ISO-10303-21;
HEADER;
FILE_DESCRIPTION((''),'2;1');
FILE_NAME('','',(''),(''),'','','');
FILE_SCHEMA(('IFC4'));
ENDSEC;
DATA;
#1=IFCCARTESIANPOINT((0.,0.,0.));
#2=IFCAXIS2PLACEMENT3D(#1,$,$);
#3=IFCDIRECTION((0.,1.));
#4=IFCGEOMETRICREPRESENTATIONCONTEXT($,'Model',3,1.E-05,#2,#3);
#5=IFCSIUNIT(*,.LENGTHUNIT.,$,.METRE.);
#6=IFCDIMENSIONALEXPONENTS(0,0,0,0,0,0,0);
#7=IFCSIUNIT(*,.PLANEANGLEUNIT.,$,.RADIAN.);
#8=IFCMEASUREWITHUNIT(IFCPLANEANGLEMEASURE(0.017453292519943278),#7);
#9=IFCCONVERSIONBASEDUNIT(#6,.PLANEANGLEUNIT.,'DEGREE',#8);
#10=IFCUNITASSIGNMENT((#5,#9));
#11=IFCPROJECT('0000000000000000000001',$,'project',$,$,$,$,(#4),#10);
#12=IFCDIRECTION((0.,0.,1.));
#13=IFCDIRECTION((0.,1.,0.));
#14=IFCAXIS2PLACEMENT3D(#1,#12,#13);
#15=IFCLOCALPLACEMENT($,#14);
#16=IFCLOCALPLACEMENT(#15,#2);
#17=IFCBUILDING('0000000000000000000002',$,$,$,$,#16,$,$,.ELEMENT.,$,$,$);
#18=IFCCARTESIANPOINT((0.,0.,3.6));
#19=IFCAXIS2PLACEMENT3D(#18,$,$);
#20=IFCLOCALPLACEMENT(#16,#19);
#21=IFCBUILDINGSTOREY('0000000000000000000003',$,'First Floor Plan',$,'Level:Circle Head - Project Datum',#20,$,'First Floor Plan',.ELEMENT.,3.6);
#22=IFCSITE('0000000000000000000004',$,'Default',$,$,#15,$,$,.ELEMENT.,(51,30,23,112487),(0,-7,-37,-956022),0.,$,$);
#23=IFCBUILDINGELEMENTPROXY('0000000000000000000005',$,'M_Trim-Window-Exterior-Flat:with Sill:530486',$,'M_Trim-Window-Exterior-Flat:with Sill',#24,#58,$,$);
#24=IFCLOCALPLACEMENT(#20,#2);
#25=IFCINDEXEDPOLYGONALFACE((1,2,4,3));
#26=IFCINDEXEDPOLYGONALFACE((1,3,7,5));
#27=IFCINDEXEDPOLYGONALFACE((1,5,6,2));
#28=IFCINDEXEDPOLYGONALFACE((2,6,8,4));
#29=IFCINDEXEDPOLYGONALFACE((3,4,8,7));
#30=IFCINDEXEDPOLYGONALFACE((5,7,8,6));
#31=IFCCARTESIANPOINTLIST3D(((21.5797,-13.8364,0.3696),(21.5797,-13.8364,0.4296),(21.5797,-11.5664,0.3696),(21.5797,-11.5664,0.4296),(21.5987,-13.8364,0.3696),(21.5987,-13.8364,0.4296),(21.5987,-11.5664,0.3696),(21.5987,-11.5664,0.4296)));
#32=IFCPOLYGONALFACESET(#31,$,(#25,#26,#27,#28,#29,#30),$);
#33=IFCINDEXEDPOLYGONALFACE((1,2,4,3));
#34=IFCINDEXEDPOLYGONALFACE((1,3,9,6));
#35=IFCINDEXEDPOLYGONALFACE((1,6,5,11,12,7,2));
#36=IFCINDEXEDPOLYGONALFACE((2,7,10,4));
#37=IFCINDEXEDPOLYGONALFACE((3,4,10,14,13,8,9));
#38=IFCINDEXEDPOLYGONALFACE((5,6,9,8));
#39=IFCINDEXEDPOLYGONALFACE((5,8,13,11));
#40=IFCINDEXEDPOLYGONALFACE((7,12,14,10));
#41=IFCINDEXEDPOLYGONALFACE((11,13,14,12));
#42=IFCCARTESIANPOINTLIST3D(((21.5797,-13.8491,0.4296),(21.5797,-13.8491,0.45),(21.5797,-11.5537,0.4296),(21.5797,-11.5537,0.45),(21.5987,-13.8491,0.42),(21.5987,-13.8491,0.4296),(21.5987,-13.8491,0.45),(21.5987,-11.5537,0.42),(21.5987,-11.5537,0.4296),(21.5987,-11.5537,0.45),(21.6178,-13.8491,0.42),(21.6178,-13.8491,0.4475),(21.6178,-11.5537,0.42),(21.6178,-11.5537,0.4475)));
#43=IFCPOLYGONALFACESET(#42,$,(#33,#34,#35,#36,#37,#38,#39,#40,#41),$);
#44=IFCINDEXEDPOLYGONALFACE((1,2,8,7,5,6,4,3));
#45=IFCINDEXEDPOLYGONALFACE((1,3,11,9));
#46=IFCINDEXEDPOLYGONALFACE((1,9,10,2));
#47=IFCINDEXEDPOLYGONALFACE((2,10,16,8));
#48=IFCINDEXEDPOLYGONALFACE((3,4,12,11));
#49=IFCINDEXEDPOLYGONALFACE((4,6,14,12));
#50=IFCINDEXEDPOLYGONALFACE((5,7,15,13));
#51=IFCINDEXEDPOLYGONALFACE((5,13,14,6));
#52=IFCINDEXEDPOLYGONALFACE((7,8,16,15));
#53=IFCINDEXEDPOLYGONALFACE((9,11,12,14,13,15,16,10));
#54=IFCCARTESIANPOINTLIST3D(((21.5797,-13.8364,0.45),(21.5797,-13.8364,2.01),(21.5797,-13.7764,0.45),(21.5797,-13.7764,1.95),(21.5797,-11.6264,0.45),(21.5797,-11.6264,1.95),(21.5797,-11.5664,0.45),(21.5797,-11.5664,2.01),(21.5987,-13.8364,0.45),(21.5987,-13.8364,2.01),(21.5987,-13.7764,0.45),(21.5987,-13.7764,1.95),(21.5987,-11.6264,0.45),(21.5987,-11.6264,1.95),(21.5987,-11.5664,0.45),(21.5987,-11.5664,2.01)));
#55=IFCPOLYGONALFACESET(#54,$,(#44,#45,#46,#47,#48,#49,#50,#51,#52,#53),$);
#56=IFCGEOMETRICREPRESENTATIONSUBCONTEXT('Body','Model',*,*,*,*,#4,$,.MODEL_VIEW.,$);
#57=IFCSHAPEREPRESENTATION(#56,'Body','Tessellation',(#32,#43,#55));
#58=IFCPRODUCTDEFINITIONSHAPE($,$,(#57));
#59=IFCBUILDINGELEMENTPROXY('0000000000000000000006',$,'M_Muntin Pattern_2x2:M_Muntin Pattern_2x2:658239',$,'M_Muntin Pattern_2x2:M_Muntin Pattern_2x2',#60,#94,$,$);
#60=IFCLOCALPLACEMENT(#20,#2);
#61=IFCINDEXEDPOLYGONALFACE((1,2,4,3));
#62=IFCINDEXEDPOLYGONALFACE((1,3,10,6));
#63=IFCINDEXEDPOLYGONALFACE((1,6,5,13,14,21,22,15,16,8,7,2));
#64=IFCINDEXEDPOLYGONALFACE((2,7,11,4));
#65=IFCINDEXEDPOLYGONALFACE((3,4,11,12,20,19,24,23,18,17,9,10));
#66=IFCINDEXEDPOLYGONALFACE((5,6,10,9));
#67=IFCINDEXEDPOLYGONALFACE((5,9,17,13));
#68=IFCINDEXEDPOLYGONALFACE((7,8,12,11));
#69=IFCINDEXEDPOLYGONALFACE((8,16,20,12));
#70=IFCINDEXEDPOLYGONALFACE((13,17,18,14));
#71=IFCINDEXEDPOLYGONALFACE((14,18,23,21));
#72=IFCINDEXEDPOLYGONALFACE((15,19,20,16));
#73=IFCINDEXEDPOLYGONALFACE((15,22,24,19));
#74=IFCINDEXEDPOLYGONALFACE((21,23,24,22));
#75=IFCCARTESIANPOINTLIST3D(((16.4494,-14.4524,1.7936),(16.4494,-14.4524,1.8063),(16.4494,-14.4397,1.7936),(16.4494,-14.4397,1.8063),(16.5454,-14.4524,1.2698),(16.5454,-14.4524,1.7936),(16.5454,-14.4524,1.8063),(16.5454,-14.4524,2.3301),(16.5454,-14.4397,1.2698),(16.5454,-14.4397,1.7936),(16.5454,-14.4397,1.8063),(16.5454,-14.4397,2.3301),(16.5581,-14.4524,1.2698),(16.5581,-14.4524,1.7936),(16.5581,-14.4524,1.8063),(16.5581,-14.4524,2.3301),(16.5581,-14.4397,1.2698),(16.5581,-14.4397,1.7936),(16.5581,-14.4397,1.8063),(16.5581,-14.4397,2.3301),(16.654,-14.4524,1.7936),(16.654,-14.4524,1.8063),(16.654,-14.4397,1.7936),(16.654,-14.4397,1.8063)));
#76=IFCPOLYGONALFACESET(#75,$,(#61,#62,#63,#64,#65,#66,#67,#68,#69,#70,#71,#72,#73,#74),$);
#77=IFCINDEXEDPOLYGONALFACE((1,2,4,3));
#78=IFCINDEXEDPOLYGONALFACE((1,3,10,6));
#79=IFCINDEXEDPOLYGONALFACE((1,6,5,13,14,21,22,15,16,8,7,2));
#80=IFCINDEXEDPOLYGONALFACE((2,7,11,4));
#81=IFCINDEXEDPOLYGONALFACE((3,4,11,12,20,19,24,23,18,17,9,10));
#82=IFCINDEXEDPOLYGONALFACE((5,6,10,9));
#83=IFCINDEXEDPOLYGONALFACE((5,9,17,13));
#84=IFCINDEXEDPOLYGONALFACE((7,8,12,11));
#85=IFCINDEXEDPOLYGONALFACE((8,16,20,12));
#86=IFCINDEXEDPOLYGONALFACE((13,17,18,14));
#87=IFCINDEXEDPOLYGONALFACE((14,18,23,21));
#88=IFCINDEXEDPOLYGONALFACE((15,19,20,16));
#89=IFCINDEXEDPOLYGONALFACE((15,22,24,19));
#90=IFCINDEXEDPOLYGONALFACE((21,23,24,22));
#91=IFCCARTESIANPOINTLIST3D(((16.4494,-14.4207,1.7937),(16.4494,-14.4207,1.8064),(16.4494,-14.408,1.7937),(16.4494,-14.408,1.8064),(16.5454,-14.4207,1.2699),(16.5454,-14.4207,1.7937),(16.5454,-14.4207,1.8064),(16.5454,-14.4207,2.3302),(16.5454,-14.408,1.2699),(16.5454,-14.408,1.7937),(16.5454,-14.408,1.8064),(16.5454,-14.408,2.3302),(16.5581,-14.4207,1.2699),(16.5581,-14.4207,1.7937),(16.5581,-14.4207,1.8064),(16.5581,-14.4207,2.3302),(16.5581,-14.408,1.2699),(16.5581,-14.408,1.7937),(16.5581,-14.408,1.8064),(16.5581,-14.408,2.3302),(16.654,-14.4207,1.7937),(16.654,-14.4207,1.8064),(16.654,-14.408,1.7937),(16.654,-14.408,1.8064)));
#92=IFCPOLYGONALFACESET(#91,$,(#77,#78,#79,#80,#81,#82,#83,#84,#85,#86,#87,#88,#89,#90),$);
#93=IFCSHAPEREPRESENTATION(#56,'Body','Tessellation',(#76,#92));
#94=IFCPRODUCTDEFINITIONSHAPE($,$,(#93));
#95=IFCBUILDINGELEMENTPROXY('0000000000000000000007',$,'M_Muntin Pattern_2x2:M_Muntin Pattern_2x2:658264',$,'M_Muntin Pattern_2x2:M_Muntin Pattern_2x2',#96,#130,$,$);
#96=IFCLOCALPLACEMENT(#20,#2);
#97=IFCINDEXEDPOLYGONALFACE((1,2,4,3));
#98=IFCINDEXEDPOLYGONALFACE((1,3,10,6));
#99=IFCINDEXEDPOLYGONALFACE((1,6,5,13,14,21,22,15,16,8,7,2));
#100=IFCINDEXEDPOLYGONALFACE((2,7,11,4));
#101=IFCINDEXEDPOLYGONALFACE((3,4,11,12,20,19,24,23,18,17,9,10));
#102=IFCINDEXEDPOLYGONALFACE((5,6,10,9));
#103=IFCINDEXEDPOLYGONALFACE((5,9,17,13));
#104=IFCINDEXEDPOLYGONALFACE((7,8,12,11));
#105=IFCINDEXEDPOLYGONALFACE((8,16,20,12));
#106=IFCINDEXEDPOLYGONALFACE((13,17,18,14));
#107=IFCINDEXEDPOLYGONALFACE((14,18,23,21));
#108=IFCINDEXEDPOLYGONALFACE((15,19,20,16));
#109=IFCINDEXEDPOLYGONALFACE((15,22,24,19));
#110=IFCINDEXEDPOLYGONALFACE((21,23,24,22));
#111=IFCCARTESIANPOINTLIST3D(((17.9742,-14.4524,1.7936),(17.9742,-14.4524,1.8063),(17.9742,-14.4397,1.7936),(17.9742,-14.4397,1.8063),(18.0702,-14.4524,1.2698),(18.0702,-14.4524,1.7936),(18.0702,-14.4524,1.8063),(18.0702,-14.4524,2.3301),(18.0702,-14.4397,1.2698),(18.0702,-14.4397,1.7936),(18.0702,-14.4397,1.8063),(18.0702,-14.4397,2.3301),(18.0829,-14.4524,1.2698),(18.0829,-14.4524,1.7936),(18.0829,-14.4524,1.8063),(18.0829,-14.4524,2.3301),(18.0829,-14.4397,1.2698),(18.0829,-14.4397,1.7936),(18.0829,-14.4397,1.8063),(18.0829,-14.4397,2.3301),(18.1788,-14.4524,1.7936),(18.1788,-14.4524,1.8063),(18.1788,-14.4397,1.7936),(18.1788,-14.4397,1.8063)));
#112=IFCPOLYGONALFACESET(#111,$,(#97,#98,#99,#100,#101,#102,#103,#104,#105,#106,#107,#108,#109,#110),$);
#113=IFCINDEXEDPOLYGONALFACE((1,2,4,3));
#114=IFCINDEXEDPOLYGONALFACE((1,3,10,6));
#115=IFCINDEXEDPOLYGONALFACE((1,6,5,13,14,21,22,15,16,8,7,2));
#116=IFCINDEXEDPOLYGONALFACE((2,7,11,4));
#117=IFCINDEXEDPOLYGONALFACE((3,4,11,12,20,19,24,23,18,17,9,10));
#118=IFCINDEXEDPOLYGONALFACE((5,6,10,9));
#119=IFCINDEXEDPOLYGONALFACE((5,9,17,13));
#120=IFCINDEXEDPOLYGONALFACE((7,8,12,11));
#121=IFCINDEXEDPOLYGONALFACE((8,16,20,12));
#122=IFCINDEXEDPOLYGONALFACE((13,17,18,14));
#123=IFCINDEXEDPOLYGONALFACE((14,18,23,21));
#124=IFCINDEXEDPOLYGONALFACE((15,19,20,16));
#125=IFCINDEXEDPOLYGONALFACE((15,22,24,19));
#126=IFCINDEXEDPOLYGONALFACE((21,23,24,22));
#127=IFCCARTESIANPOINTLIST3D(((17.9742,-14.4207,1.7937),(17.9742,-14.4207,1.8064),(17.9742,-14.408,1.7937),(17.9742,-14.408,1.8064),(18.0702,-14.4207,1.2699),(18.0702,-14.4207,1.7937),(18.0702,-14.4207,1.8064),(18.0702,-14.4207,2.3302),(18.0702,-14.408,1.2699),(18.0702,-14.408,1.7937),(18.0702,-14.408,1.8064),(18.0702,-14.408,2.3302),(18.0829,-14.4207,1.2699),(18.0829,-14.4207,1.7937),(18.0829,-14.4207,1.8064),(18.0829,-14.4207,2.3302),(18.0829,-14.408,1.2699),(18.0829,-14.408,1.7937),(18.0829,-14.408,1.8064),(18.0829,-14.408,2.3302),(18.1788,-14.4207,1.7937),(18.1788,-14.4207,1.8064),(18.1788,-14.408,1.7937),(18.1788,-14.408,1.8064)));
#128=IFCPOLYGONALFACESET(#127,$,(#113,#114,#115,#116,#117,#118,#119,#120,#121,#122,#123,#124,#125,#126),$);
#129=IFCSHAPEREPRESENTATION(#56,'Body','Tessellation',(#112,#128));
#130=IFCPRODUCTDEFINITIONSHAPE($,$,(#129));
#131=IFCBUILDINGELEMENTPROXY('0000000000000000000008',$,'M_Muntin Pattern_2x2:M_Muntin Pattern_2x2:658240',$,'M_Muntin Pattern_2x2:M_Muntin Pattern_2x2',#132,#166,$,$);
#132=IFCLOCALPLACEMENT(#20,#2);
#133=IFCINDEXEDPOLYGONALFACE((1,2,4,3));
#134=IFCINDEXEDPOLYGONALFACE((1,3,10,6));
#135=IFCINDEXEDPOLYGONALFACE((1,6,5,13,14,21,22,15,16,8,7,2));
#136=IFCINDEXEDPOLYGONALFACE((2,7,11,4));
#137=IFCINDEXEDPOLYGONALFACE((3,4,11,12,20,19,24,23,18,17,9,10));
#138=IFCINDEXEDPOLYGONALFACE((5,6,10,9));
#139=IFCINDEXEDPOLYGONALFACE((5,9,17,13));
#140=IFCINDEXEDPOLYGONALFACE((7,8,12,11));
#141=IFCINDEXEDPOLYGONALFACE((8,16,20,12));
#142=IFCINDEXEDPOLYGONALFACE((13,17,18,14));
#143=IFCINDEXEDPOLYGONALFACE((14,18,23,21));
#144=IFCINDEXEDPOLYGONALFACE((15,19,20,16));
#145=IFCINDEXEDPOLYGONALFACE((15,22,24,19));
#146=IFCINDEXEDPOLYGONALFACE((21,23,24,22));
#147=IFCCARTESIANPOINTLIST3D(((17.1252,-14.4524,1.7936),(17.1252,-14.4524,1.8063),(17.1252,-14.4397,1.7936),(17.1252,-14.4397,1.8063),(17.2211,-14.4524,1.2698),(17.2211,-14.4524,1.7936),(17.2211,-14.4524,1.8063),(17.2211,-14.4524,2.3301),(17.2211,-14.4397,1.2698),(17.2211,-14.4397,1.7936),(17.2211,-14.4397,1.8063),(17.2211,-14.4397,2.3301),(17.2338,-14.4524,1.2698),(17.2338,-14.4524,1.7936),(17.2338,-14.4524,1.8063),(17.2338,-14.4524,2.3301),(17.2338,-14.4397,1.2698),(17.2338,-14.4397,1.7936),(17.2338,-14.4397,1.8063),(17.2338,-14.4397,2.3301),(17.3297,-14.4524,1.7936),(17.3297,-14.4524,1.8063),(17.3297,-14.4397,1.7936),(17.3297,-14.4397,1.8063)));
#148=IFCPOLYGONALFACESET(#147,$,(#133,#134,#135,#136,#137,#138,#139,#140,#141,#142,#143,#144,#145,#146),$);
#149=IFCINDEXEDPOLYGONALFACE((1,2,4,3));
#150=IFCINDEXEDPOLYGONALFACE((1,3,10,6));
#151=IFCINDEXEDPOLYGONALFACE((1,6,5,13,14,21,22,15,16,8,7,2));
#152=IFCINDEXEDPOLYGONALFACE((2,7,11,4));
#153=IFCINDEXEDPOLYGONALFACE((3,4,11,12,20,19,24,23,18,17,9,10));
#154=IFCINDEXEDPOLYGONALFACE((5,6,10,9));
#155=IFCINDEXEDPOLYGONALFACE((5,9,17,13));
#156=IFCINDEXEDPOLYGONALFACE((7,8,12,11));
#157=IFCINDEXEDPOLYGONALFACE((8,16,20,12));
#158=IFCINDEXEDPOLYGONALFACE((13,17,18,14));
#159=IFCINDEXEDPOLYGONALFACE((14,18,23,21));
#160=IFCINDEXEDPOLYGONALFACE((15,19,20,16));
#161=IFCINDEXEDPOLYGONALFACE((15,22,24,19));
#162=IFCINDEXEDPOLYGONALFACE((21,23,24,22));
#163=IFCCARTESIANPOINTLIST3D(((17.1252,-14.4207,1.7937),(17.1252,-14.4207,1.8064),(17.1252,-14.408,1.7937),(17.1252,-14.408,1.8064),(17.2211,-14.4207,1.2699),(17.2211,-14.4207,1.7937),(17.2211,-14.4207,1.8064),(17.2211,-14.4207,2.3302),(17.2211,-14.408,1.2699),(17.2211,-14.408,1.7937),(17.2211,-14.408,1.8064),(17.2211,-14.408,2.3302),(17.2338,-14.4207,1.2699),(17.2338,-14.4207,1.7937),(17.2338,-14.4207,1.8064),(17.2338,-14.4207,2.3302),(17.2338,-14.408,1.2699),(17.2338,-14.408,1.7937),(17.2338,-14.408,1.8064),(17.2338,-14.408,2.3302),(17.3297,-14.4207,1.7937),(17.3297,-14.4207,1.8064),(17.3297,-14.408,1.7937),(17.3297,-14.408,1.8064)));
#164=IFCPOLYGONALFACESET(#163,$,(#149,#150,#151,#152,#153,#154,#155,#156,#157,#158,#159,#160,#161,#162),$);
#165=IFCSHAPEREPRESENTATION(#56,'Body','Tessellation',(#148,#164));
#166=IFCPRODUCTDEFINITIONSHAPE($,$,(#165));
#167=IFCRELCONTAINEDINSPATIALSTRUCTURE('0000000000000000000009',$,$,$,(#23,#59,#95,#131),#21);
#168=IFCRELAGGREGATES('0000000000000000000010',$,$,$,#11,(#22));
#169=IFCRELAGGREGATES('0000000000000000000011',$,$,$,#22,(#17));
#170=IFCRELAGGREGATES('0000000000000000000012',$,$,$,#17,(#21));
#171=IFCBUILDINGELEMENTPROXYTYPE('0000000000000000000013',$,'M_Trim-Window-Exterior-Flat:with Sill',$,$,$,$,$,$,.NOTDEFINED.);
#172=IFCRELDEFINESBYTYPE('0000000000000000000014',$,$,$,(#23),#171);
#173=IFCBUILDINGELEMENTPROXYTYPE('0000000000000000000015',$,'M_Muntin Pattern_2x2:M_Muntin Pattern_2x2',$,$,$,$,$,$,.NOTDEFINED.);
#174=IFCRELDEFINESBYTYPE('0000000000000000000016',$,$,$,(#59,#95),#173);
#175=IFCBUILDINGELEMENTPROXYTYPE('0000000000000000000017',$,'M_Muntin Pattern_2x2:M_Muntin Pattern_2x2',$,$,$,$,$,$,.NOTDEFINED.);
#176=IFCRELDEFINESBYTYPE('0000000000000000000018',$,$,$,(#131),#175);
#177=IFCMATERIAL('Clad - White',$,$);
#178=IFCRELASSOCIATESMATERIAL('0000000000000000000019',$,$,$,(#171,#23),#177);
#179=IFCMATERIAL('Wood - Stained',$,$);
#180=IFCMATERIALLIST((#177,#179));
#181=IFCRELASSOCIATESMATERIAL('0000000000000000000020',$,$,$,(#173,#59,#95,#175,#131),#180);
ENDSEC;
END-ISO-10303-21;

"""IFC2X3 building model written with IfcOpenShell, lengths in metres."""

from ifc_helpers import new_model, entity, si_unit, converted_unit, direction, frame, frame_2d, origin, place, context, subcontext, project, spatial, polyline, rectangle, outline, extrude, source, transform, mapped, material, material_list, type_object, type_shapes, element, save


model = new_model("IFC2X3")

# Units and contexts
model_context = context("Model", 3, precision=1e-05, world=origin(), true_north=direction((0.0, 1.0)))
body_context = subcontext(model_context, "Body", "Model", "MODEL_VIEW")
ifc_project = project(units=[si_unit("LENGTHUNIT", "METRE"), converted_unit("PLANEANGLEUNIT", "DEGREE", entity("IfcPlaneAngleMeasure", 0.017453292519943278), si_unit("PLANEANGLEUNIT", "RADIAN"), dimensions=[0, 0, 0, 0, 0, 0, 0])], contexts=[model_context])

# Site, building, storey
site_placement = place(None, frame((0.0, 0.0, 0.0), z_axis=(0.0, 0.0, 1.0), x_axis=(0.0, 1.0, 0.0)))
site = spatial("IfcSite", under=ifc_project, at=site_placement, Name="Default", CompositionType="ELEMENT", RefLatitude=(51, 30, 23, 112487), RefLongitude=(0, -7, -37, -956022), RefElevation=0.0)
building_placement = place(site_placement, origin())
building = spatial("IfcBuilding", under=site, at=building_placement, CompositionType="ELEMENT")
storey_placement = place(building_placement, frame((0.0, 0.0, 3.6)))
storey = spatial("IfcBuildingStorey", under=building, at=storey_placement, Name="First Floor Plan", ObjectType="Level:Circle Head - Project Datum", LongName="First Floor Plan", CompositionType="ELEMENT", Elevation=3.6)

# Building element proxies
ifc_material_1 = material(Name="Clad - White")
ifc_material_2 = material(Name="Wood - Stained")
ifc_material_list = material_list([ifc_material_1, ifc_material_2])
building_element_proxy_type_1 = type_object("IfcBuildingElementProxyType", Name="M_Trim-Window-Exterior-Flat:with Sill", PredefinedType="NOTDEFINED", material=ifc_material_1)
shared_shape_1 = source(origin(), body_context, "Body", "SweptSolid", [
    extrude(rectangle(XDim=2.27, YDim=0.06, at=frame_2d((0.0, 0.0), x_axis=(1.0, 0.0))), frame((0.0, -1.5504, 0.0), z_axis=(0.0, 0.0, 1.0), x_axis=(-1.0, 0.0, 0.0)), (0.0, 0.0, 1.0), 0.019),
    extrude(outline(polyline([(-0.019, -0.0152), (0.0, -0.0152), (0.0, -0.0057), (0.019, -0.0057), (0.019, 0.0148), (0.0, 0.0148), (-0.019, 0.0123), (-0.019, -0.0152)])), frame((-1.1477, -1.5148, 0.019), z_axis=(1.0, 0.0, 0.0), x_axis=(0.0, 0.0, -1.0)), (0.0, 0.0, 1.0), 2.2954),
    extrude(outline(polyline([(-0.795, -1.135), (0.765, -1.135), (0.765, -1.075), (-0.735, -1.075), (-0.735, 1.075), (0.765, 1.075), (0.765, 1.135), (-0.795, 1.135), (-0.795, -1.135)])), frame((0.0, -0.735, 0.0), z_axis=(0.0, 0.0, 1.0), x_axis=(0.0, -1.0, 0.0)), (0.0, 0.0, 1.0), 0.019),
])
type_shapes(building_element_proxy_type_1, [shared_shape_1])
proxy_1_placement = place(storey_placement, frame((21.5797, -12.7014, 1.95), z_axis=(1.0, 0.0, 0.0), x_axis=(0.0, 1.0, 0.0)))
element("IfcBuildingElementProxy", 1, at=proxy_1_placement, inside=storey, type_object=building_element_proxy_type_1, material=ifc_material_1, Name="M_Trim-Window-Exterior-Flat:with Sill:530486", ObjectType="M_Trim-Window-Exterior-Flat:with Sill", context=body_context, shape_type="MappedRepresentation", body=[
    mapped(shared_shape_1, transform((0.0, 0.0, 0.0), scale=1.0)),
])
building_element_proxy_type_2 = type_object("IfcBuildingElementProxyType", Name="M_Muntin Pattern_2x2:M_Muntin Pattern_2x2", PredefinedType="NOTDEFINED", material=ifc_material_list)
shared_shape_2 = source(origin(), body_context, "Body", "SweptSolid", [
    extrude(outline(polyline([(0.0064, -0.0064), (0.5301, -0.0064), (0.5301, 0.0063), (0.0064, 0.0063), (0.0064, 0.1023), (-0.0063, 0.1023), (-0.0063, 0.0063), (-0.5302, 0.0063), (-0.5302, -0.0064), (-0.0063, -0.0064), (-0.0063, -0.1023), (0.0064, -0.1023), (0.0064, -0.0064)])), frame((0.0, -0.0222, 0.5301), z_axis=(0.0, 1.0, 0.0), x_axis=(0.0, 0.0, 1.0)), (0.0, 0.0, 1.0), 0.0127),
    extrude(outline(polyline([(0.0064, -0.0064), (0.5302, -0.0064), (0.5302, 0.0063), (0.0064, 0.0063), (0.0064, 0.1023), (-0.0063, 0.1023), (-0.0063, 0.0063), (-0.5302, 0.0063), (-0.5302, -0.0064), (-0.0063, -0.0064), (-0.0063, -0.1023), (0.0064, -0.1023), (0.0064, -0.0064)])), frame((0.0, 0.0095, 0.5302), z_axis=(0.0, 1.0, 0.0), x_axis=(0.0, 0.0, 1.0)), (0.0, 0.0, 1.0), 0.0127),
])
type_shapes(building_element_proxy_type_2, [shared_shape_2])
for number, where, name in (
    (2, (16.5517, -14.4302, 1.2699), "M_Muntin Pattern_2x2:M_Muntin Pattern_2x2:658239"),
    (3, (18.0765, -14.4302, 1.2699), "M_Muntin Pattern_2x2:M_Muntin Pattern_2x2:658264"),
):
    element("IfcBuildingElementProxy", number, at=place(storey_placement, frame(where)), inside=storey, type_object=building_element_proxy_type_2, material=ifc_material_list, Name=name, ObjectType="M_Muntin Pattern_2x2:M_Muntin Pattern_2x2", context=body_context, shape_type="MappedRepresentation", body=[
        mapped(shared_shape_2, transform((0.0, 0.0, 0.0), scale=1.0)),
    ])
building_element_proxy_type_3 = type_object("IfcBuildingElementProxyType", Name="M_Muntin Pattern_2x2:M_Muntin Pattern_2x2", PredefinedType="NOTDEFINED", material=ifc_material_list)
shared_shape_3 = source(origin(), body_context, "Body", "SweptSolid", [
    extrude(outline(polyline([(0.0064, -0.0064), (0.5301, -0.0064), (0.5301, 0.0063), (0.0064, 0.0063), (0.0064, 0.1023), (-0.0063, 0.1023), (-0.0063, 0.0063), (-0.5302, 0.0063), (-0.5302, -0.0064), (-0.0063, -0.0064), (-0.0063, -0.1023), (0.0064, -0.1023), (0.0064, -0.0064)])), frame((0.0, 0.0095, 0.5301), z_axis=(0.0, 1.0, 0.0), x_axis=(0.0, 0.0, 1.0)), (0.0, 0.0, 1.0), 0.0127),
    extrude(outline(polyline([(0.0064, -0.0064), (0.5302, -0.0064), (0.5302, 0.0063), (0.0064, 0.0063), (0.0064, 0.1023), (-0.0063, 0.1023), (-0.0063, 0.0063), (-0.5302, 0.0063), (-0.5302, -0.0064), (-0.0063, -0.0064), (-0.0063, -0.1023), (0.0064, -0.1023), (0.0064, -0.0064)])), frame((0.0, -0.0222, 0.5302), z_axis=(0.0, 1.0, 0.0), x_axis=(0.0, 0.0, 1.0)), (0.0, 0.0, 1.0), 0.0127),
])
type_shapes(building_element_proxy_type_3, [shared_shape_3])
for number, where, z_axis, x_axis, name in (
    (4, (17.2275, -14.4302, 1.2699), (0.0, 0.0, 1.0), (-1.0, 0.0, 0.0), "M_Muntin Pattern_2x2:M_Muntin Pattern_2x2:658240"),
):
    element("IfcBuildingElementProxy", number, at=place(storey_placement, frame(where, z_axis=z_axis, x_axis=x_axis)), inside=storey, type_object=building_element_proxy_type_3, material=ifc_material_list, Name=name, ObjectType="M_Muntin Pattern_2x2:M_Muntin Pattern_2x2", context=body_context, shape_type="MappedRepresentation", body=[
        mapped(shared_shape_3, transform((0.0, 0.0, 0.0), scale=1.0)),
    ])

save(model, "model.ifc")
